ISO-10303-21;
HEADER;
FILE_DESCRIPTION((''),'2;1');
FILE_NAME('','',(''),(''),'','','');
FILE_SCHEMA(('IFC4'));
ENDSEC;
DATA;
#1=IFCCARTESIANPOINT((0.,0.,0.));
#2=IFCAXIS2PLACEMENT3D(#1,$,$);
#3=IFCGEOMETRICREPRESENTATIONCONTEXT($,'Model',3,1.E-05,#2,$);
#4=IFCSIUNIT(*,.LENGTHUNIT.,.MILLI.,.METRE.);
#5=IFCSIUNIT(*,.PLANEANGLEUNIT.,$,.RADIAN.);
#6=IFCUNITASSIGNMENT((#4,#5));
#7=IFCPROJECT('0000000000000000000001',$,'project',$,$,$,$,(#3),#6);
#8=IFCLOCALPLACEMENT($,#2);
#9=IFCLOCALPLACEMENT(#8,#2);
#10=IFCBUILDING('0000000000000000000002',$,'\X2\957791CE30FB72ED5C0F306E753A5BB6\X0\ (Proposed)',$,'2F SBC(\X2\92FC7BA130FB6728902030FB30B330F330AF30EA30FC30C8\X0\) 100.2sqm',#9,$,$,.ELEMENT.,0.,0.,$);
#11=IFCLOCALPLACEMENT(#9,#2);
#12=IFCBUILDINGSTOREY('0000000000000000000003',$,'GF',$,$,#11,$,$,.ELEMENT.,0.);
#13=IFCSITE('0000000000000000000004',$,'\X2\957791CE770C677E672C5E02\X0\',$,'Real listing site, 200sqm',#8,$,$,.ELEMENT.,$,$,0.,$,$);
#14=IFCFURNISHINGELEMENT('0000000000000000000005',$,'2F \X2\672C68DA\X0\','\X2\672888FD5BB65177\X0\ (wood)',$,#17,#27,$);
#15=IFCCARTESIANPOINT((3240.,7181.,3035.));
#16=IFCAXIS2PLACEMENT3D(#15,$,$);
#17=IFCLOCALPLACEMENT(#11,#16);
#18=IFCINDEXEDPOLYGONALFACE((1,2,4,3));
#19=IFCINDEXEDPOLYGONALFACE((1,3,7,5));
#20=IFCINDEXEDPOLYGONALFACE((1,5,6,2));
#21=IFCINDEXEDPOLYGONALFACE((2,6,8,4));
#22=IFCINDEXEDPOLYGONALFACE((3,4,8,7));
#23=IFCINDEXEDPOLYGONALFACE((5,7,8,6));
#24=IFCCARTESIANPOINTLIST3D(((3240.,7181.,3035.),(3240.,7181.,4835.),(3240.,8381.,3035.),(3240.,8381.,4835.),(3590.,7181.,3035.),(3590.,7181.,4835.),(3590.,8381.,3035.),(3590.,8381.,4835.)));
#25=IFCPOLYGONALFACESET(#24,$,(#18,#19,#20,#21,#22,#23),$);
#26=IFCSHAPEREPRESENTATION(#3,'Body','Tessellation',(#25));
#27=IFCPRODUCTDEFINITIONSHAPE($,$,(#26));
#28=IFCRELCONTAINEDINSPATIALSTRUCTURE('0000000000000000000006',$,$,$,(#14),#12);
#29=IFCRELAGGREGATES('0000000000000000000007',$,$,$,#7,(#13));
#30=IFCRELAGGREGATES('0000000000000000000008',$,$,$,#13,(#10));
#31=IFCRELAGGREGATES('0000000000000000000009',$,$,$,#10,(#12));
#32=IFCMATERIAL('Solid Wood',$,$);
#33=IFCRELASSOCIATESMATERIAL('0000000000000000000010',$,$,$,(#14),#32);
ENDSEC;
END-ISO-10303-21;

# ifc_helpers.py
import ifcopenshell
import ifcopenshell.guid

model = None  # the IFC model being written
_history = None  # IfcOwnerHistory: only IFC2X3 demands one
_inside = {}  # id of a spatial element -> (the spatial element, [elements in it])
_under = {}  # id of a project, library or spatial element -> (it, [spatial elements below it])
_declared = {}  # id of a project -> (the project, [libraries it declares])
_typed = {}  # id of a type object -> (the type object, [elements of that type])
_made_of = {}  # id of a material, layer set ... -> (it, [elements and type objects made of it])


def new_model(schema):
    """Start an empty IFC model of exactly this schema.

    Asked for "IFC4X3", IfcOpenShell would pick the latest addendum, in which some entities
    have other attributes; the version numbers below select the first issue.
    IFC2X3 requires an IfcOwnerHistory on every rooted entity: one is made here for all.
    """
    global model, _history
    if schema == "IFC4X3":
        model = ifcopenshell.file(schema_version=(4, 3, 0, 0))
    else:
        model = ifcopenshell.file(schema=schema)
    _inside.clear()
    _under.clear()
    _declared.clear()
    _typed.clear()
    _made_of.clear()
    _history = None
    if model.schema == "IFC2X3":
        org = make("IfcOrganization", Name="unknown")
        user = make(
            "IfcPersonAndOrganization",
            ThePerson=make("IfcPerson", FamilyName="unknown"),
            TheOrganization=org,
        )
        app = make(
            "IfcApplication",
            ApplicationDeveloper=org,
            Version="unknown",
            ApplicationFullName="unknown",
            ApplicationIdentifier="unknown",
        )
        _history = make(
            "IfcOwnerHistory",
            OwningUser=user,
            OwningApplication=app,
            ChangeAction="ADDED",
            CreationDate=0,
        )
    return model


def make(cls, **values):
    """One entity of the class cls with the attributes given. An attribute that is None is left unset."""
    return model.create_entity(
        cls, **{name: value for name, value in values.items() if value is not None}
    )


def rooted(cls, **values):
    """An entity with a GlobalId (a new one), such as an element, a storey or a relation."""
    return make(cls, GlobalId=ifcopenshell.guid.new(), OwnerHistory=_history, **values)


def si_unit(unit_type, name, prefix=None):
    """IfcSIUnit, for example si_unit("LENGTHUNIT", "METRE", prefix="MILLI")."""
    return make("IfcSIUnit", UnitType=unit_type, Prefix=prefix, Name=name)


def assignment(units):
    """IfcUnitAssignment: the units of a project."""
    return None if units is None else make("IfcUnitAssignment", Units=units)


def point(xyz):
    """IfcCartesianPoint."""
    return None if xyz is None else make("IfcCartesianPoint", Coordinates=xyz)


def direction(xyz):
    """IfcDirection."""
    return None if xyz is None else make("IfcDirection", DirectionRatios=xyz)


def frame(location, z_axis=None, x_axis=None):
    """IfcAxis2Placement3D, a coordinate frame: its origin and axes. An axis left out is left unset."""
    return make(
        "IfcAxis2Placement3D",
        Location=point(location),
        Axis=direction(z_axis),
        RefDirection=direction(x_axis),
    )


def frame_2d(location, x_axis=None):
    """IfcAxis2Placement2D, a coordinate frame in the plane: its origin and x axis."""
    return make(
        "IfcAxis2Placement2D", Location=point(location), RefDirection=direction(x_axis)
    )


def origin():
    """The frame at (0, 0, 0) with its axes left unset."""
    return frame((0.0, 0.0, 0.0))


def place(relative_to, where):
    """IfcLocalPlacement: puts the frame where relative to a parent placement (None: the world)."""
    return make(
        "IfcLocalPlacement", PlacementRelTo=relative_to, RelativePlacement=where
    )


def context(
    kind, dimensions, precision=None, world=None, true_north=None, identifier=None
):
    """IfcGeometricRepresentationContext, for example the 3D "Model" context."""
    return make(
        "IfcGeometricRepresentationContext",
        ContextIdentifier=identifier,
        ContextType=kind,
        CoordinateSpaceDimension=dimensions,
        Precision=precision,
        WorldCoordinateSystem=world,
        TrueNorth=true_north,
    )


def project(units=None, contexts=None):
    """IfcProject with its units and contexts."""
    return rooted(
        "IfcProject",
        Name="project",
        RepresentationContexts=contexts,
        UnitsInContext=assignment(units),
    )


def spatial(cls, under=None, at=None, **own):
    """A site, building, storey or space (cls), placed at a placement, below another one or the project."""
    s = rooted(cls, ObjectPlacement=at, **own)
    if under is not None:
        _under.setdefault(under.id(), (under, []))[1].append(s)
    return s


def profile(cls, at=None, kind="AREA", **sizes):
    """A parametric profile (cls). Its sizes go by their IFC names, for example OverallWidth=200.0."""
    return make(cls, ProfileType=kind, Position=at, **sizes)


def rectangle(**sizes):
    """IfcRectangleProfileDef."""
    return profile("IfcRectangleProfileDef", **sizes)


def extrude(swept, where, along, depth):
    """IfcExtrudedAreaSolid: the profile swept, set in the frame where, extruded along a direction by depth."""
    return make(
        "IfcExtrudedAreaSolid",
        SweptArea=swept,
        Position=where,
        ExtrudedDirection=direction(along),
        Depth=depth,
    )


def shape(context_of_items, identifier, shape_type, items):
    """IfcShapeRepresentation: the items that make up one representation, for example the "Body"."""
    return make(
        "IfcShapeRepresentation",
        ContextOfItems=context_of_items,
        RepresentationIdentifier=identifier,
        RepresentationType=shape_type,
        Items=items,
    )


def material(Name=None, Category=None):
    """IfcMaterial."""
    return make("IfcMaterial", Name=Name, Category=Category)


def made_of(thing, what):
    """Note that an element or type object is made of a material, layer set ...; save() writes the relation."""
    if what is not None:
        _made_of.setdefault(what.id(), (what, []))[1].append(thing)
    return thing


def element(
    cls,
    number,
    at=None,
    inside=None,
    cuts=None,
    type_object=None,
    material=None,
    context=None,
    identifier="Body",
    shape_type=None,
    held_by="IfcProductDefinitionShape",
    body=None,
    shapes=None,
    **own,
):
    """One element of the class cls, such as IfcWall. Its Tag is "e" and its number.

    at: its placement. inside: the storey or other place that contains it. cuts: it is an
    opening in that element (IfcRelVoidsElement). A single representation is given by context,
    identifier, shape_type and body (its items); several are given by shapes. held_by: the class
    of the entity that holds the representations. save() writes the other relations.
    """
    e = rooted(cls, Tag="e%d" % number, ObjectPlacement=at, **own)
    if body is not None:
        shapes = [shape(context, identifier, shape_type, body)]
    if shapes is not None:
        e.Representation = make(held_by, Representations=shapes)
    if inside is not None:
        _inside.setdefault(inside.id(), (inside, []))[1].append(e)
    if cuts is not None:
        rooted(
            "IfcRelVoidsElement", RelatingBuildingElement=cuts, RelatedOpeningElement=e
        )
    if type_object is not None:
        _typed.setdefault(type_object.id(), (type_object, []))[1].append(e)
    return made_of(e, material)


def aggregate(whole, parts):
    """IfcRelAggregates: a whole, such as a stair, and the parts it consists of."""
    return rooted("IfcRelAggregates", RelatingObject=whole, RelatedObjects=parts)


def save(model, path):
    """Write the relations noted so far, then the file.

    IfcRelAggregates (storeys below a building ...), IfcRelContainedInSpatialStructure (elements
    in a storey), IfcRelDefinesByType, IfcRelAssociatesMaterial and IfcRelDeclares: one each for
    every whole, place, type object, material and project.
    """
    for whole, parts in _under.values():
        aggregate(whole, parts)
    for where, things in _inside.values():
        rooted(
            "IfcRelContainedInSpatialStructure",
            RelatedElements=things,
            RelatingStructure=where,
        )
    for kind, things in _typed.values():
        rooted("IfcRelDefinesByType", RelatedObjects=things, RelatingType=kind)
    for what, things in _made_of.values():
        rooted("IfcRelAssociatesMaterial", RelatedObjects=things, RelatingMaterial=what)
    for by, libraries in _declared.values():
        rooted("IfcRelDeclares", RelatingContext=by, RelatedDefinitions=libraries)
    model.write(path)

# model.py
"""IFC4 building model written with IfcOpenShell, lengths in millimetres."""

from ifc_helpers import new_model, si_unit, frame, frame_2d, origin, place, context, project, spatial, rectangle, extrude, material, element, save


model = new_model("IFC4")

# Units and contexts
model_context = context("Model", 3, precision=1e-05, world=origin())
ifc_project = project(units=[si_unit("LENGTHUNIT", "METRE", prefix="MILLI"), si_unit("PLANEANGLEUNIT", "RADIAN")], contexts=[model_context])

# Site, building, storey
site_placement = place(None, origin())
site = spatial("IfcSite", under=ifc_project, at=site_placement, Name="長野県松本市", ObjectType="Real listing site, 200sqm", CompositionType="ELEMENT", RefElevation=0.0)
building_placement = place(site_placement, origin())
building = spatial("IfcBuilding", under=site, at=building_placement, Name="長野・狭小の町家 (Proposed)", ObjectType="2F SBC(鋼管・木造・コンクリート) 100.2sqm", CompositionType="ELEMENT", ElevationOfRefHeight=0.0, ElevationOfTerrain=0.0)
storey_placement = place(building_placement, origin())
storey = spatial("IfcBuildingStorey", under=building, at=storey_placement, Name="GF", CompositionType="ELEMENT", Elevation=0.0)

# Shared definitions
ifc_material_1 = material(Name="Solid Wood")

# Furnishing element
furnishing_placement = place(storey_placement, frame((3240.0, 7181.0, 3035.0)))
element("IfcFurnishingElement", 1, at=furnishing_placement, inside=storey, material=ifc_material_1, Name="2F 本棚", Description="木製家具 (wood)", context=model_context, shape_type="SweptSolid", body=[
    extrude(rectangle(XDim=350.0, YDim=1200.0, at=frame_2d((175.0, 600.0))), frame((3240.0, 7181.0, 3035.0)), (0.0, 0.0, 1.0), 1800.0),
])

save(model, "model.ifc")
